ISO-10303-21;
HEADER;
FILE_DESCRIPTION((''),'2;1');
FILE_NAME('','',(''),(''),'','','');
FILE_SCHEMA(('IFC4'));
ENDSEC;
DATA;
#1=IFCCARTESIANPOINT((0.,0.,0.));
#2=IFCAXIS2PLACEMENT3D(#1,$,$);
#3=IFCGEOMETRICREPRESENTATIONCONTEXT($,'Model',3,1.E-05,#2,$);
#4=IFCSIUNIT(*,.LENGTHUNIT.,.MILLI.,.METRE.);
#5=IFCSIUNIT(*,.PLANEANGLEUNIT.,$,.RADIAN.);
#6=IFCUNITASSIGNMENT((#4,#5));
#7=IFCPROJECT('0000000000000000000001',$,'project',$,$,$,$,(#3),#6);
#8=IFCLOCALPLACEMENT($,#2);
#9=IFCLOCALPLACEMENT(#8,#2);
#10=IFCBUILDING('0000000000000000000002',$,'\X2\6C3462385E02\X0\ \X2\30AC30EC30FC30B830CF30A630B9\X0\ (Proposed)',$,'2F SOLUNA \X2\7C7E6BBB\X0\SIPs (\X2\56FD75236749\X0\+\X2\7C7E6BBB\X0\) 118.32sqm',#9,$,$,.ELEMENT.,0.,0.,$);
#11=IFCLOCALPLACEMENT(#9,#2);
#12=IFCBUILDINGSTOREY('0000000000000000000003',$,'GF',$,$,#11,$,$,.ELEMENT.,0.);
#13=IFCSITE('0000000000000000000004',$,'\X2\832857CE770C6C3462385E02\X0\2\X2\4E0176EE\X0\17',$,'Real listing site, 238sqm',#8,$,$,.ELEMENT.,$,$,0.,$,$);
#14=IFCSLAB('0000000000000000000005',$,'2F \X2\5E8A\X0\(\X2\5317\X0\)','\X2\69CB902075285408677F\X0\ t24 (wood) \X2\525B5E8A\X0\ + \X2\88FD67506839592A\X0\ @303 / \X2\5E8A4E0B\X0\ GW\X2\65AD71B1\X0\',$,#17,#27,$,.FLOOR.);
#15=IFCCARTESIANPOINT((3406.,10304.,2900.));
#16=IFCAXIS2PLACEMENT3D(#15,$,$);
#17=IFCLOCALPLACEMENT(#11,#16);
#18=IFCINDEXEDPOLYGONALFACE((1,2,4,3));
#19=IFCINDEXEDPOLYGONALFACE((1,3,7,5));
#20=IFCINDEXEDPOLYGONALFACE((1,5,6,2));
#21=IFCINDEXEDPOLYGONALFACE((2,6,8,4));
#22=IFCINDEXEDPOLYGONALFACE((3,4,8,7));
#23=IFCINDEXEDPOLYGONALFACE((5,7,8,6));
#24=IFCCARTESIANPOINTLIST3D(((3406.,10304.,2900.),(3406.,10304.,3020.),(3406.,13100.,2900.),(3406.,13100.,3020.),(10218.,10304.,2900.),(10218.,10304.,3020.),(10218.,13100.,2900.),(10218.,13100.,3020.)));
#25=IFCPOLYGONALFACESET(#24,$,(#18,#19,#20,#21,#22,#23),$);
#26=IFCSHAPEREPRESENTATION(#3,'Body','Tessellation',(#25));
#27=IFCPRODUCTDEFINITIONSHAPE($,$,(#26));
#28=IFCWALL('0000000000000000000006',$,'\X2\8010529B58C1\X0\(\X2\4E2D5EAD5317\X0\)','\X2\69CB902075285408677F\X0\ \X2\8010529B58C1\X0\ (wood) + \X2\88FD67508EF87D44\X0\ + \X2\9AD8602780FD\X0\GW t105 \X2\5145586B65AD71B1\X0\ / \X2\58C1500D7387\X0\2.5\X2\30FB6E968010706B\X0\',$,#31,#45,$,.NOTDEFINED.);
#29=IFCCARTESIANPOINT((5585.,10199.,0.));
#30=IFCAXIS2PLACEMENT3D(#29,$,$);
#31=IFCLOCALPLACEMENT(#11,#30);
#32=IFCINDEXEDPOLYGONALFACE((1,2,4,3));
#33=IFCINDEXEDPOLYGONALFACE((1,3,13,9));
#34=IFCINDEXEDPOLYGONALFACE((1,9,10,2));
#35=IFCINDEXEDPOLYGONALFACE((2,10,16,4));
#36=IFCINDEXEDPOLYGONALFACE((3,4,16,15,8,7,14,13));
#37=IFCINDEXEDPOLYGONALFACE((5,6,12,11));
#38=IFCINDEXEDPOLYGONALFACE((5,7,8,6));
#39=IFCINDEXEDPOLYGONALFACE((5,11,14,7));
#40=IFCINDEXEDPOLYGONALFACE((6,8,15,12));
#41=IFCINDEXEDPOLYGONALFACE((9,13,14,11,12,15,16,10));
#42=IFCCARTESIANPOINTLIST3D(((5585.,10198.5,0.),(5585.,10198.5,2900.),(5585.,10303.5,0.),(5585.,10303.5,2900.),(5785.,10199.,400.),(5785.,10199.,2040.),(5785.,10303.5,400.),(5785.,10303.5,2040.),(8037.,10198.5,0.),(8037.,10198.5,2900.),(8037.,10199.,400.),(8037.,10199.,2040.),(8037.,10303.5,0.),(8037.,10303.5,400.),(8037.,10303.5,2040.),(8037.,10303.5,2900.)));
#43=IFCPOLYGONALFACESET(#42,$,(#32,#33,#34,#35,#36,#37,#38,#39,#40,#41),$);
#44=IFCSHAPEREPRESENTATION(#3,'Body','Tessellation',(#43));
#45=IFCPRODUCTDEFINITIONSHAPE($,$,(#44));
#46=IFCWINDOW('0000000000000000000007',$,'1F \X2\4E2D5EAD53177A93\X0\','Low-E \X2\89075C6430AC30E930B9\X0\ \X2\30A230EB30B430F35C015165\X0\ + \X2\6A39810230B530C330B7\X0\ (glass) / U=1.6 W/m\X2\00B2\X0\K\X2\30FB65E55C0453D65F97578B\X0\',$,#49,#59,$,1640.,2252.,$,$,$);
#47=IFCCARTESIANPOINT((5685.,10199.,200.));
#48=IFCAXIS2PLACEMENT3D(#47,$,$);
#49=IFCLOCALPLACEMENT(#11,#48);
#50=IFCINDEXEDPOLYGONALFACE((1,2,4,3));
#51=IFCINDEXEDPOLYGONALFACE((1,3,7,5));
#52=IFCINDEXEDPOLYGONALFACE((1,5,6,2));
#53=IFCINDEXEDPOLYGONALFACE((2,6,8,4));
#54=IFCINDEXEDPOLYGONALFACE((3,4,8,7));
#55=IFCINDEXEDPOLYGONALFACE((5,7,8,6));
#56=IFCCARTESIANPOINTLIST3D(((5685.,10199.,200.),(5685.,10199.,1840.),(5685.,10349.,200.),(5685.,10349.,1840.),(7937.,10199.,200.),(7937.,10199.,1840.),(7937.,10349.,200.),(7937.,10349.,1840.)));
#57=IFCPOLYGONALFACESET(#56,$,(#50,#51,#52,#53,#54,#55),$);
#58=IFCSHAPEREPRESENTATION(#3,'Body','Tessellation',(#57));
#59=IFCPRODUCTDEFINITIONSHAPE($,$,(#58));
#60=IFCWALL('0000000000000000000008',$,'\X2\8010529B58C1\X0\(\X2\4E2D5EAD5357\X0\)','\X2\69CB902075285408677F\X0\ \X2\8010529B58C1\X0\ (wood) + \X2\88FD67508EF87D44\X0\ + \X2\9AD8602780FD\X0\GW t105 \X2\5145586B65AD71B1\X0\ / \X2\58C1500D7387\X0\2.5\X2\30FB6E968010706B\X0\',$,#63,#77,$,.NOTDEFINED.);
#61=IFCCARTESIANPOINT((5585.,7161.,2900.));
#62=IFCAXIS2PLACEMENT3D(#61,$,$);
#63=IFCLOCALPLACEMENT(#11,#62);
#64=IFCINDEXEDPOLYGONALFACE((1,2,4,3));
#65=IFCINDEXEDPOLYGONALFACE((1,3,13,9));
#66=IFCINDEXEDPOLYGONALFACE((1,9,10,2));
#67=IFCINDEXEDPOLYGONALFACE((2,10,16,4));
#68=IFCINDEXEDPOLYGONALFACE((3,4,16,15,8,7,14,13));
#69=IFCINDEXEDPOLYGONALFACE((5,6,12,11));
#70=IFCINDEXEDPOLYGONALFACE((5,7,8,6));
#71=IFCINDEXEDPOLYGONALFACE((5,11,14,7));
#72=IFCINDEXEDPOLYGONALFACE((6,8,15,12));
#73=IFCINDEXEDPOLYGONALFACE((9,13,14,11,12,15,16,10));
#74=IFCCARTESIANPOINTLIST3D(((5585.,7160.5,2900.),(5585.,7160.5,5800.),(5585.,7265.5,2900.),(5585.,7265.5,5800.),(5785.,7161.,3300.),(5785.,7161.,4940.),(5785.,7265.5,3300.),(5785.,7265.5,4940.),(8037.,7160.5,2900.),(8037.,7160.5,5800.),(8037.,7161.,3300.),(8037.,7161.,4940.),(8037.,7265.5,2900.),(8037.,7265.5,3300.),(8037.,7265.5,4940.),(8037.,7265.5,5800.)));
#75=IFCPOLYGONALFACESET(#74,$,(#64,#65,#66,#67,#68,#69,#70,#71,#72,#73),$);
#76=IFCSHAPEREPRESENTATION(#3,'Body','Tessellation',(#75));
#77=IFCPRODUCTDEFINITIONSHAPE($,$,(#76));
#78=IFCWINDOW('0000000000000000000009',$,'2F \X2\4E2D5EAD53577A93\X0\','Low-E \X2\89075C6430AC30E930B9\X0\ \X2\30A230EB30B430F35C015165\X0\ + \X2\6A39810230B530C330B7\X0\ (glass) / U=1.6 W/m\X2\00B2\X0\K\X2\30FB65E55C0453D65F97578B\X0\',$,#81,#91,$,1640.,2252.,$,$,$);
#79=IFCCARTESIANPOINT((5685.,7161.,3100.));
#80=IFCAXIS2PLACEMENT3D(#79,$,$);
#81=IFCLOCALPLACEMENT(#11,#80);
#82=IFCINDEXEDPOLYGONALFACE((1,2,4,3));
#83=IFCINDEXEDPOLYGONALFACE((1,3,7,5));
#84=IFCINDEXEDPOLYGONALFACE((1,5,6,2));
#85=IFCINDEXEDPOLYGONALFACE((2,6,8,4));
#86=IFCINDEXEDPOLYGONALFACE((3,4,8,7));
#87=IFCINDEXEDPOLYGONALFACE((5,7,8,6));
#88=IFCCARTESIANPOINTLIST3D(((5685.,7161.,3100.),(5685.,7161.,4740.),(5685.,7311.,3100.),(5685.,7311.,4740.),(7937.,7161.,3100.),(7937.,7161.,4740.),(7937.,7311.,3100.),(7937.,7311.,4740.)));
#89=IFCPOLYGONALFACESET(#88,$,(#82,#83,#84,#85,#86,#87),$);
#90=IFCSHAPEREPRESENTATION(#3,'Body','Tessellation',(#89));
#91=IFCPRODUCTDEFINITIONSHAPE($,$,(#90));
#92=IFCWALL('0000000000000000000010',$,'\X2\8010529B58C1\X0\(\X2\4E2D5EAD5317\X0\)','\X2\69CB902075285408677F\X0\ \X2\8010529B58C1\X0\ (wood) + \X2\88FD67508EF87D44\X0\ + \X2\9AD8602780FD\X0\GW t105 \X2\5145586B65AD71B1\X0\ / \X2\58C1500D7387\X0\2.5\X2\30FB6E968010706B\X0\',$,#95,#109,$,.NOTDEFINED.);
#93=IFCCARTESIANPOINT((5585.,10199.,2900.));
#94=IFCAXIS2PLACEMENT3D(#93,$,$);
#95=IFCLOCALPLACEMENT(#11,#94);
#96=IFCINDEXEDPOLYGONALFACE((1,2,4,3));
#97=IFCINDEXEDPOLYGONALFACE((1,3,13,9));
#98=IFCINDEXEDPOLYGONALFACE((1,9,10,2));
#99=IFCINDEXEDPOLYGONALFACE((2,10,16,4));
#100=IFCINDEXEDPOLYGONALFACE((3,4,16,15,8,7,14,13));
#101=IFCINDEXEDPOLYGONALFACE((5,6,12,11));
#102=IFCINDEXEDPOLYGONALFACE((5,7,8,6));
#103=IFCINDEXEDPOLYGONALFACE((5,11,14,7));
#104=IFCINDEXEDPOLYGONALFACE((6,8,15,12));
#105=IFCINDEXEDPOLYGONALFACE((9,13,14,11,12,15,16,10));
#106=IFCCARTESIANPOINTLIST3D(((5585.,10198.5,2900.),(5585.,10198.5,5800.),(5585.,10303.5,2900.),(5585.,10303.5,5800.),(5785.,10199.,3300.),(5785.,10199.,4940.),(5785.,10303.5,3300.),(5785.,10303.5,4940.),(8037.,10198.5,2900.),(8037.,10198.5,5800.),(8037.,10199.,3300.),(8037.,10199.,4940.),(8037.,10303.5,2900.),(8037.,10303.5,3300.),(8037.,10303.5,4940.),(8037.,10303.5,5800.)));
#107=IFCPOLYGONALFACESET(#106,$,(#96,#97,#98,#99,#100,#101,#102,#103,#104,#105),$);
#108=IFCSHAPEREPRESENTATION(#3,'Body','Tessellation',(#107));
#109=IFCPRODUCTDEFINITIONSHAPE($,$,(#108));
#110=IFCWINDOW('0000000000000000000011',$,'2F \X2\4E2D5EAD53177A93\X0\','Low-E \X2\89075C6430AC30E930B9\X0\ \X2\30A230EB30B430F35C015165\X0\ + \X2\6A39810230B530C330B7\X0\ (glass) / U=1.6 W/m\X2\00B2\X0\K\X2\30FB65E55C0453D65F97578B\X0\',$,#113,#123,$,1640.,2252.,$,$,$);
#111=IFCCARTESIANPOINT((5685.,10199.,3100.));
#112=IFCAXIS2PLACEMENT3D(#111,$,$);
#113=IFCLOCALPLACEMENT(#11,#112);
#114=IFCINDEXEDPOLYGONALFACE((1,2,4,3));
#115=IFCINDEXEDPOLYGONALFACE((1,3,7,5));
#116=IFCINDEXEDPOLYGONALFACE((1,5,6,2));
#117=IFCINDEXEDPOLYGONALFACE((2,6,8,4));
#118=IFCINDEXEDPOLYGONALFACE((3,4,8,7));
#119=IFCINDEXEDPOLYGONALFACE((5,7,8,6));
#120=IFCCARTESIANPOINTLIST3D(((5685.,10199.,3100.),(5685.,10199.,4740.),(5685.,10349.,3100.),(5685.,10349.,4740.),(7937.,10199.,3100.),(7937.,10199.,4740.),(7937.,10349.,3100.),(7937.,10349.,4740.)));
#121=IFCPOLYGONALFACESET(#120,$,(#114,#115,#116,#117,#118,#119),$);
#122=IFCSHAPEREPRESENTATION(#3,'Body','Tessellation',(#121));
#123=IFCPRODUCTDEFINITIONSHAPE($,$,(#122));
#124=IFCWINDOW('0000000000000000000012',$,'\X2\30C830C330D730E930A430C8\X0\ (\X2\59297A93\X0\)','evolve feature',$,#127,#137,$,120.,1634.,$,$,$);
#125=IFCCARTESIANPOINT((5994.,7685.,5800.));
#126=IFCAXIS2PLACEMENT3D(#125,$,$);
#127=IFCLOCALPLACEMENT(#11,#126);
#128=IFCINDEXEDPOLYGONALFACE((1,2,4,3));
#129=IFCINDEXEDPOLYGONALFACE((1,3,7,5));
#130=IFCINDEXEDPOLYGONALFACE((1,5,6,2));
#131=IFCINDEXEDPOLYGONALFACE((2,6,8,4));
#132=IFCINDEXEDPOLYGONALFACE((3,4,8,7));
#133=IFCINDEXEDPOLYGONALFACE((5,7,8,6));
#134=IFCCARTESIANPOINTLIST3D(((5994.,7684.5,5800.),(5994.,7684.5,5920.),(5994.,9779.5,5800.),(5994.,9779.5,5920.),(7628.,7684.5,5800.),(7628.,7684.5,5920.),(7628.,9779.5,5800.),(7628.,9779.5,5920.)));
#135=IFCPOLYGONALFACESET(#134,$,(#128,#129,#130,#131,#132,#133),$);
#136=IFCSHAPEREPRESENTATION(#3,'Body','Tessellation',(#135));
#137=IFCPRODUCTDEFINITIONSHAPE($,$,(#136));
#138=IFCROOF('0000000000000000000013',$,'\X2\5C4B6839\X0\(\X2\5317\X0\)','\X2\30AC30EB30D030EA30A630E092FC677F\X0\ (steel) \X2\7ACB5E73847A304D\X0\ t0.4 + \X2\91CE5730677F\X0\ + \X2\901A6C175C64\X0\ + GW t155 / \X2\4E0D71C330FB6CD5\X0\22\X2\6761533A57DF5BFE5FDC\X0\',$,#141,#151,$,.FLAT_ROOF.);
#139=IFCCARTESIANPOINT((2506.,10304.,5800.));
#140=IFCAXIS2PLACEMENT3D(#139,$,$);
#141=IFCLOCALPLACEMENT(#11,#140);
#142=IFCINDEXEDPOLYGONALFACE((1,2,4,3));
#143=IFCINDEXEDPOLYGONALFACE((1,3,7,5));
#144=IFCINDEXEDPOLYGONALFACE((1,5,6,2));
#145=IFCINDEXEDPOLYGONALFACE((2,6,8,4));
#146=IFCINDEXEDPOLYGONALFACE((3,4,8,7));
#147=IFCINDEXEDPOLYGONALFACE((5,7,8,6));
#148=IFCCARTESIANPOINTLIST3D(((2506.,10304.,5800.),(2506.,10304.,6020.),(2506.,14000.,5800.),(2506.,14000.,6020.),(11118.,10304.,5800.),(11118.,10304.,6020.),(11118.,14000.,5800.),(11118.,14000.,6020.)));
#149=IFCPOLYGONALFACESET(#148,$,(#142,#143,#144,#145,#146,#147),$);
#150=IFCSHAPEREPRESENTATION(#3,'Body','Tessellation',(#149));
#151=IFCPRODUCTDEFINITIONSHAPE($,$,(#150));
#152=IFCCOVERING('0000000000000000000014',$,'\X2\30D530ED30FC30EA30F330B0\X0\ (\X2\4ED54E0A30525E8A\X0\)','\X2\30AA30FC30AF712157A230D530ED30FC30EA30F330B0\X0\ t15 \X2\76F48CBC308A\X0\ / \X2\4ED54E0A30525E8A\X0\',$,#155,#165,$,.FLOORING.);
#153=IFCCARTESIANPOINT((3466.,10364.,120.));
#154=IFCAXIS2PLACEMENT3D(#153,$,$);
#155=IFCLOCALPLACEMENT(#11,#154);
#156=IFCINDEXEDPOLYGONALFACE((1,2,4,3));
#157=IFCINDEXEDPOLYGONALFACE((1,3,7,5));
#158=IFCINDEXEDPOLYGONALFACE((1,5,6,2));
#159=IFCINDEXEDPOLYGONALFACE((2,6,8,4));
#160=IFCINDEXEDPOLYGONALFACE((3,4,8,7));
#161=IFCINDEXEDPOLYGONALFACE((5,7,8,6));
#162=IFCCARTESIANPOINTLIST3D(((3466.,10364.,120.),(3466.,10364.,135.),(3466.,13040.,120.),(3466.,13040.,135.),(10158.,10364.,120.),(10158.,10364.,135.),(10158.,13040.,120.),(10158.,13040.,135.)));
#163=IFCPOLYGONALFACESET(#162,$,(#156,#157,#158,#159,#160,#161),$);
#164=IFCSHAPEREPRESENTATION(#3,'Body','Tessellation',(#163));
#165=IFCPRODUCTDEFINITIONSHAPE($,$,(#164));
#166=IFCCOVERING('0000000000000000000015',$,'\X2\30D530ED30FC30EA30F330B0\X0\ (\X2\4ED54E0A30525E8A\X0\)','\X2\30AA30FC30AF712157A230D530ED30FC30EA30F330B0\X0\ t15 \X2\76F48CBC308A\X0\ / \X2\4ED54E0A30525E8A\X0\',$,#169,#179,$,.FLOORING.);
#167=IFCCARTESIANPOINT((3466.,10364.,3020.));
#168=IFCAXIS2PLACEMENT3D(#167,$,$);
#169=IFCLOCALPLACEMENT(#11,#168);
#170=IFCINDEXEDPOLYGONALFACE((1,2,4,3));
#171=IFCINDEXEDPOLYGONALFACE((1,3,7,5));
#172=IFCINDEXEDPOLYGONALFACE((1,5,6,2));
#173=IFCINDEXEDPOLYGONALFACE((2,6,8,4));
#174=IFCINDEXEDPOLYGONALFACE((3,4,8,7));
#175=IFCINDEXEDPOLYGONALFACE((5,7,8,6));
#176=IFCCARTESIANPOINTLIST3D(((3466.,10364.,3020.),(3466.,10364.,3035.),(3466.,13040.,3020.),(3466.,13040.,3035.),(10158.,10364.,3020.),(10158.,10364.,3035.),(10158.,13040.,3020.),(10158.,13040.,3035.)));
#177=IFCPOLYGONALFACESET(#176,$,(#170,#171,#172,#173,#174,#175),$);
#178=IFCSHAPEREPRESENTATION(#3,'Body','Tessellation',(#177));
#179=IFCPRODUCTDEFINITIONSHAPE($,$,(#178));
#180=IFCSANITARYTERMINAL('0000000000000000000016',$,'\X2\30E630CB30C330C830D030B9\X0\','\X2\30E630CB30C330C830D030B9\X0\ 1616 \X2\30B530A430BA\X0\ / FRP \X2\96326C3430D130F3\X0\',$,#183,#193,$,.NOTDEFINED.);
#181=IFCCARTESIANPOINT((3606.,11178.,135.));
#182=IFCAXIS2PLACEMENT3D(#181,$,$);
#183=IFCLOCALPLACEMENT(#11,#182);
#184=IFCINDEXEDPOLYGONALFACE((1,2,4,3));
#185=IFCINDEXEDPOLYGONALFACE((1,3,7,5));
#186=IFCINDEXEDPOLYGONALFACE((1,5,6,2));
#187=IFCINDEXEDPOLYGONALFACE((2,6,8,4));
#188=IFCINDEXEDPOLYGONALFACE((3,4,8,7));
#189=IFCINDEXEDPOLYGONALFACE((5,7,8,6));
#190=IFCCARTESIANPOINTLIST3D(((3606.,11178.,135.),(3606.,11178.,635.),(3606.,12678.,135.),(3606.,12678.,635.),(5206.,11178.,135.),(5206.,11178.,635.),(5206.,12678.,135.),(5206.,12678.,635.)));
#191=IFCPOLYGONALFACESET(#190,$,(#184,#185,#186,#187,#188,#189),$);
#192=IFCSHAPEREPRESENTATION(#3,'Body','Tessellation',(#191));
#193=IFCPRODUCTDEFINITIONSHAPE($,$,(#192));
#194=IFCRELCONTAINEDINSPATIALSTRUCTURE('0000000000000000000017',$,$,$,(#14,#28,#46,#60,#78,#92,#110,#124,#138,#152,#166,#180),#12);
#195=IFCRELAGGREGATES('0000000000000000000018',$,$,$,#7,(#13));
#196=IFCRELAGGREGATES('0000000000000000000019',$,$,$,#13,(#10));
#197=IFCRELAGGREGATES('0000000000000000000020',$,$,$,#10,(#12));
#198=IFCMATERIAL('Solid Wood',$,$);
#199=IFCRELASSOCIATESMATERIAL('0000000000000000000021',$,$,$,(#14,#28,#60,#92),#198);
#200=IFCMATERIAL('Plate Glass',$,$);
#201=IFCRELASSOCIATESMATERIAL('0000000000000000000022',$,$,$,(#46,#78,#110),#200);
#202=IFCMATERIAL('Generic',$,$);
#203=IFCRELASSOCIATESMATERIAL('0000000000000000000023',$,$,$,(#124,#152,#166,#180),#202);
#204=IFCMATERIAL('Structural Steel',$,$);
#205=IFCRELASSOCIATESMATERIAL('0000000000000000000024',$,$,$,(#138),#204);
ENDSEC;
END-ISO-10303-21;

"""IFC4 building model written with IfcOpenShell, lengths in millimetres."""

from ifc_helpers import new_model, si_unit, frame, frame_2d, origin, place, context, project, spatial, rectangle, extrude, material, element, fill, save


model = new_model("IFC4")

# Units and contexts
model_context = context("Model", 3, precision=1e-05, world=origin())
ifc_project = project(units=[si_unit("LENGTHUNIT", "METRE", prefix="MILLI"), si_unit("PLANEANGLEUNIT", "RADIAN")], contexts=[model_context])

# Site, building, storey
site_placement = place(None, origin())
site = spatial("IfcSite", under=ifc_project, at=site_placement, Name="茨城県水戸市2丁目17", ObjectType="Real listing site, 238sqm", CompositionType="ELEMENT", RefElevation=0.0)
building_placement = place(site_placement, origin())
building = spatial("IfcBuilding", under=site, at=building_placement, Name="水戸市 ガレージハウス (Proposed)", ObjectType="2F SOLUNA 籾殻SIPs (国産杉+籾殻) 118.32sqm", CompositionType="ELEMENT", ElevationOfRefHeight=0.0, ElevationOfTerrain=0.0)
storey_placement = place(building_placement, origin())
storey = spatial("IfcBuildingStorey", under=building, at=storey_placement, Name="GF", CompositionType="ELEMENT", Elevation=0.0)

# Slab
ifc_material_1 = material(Name="Solid Wood")
slab_1_placement = place(storey_placement, frame((3406.0, 10304.0, 2900.0)))
element("IfcSlab", 1, at=slab_1_placement, inside=storey, material=ifc_material_1, Name="2F 床(北)", Description="構造用合板 t24 (wood) 剛床 + 製材根太 @303 / 床下 GW断熱", PredefinedType="FLOOR", context=model_context, shape_type="SweptSolid", body=[
    extrude(rectangle(XDim=6812.0, YDim=2796.0, at=frame_2d((3406.0, 1398.0))), frame((3406.0, 10304.0, 2900.0)), (0.0, 0.0, 1.0), 120.0),
])

# Wall, opening, window
wall_1_placement = place(storey_placement, frame((5585.0, 10199.0, 0.0)))
wall_1 = element("IfcWall", 2, at=wall_1_placement, inside=storey, material=ifc_material_1, Name="耐力壁(中庭北)", Description="構造用合板 耐力壁 (wood) + 製材軸組 + 高性能GW t105 充填断熱 / 壁倍率2.5・準耐火", PredefinedType="NOTDEFINED", context=model_context, shape_type="SweptSolid", body=[
    extrude(rectangle(XDim=2452.0, YDim=105.0, at=frame_2d((1226.0, 52.0))), frame((5585.0, 10199.0, 0.0)), (0.0, 0.0, 1.0), 2900.0),
])
opening_1_placement = place(storey_placement, frame((5685.0, 10199.0, 200.0)))
opening_1 = element("IfcOpeningElement", 3, at=opening_1_placement, cuts=wall_1, PredefinedType="NOTDEFINED", context=model_context, shape_type="SweptSolid", body=[
    extrude(rectangle(XDim=2252.0, YDim=150.0, at=frame_2d((1126.0, 75.0))), frame((5685.0, 10199.0, 200.0)), (0.0, 0.0, 1.0), 1640.0),
])
ifc_material_2 = material(Name="Plate Glass")
window_1_placement = place(storey_placement, frame((5685.0, 10199.0, 200.0)))
window_1 = element("IfcWindow", 4, at=window_1_placement, inside=storey, material=ifc_material_2, Name="1F 中庭北窓", Description="Low-E 複層ガラス アルゴン封入 + 樹脂サッシ (glass) / U=1.6 W/m²K・日射取得型", OverallHeight=1640.0, OverallWidth=2252.0, context=model_context, shape_type="SweptSolid", body=[
    extrude(rectangle(XDim=2252.0, YDim=150.0, at=frame_2d((1126.0, 75.0))), frame((5685.0, 10199.0, 200.0)), (0.0, 0.0, 1.0), 1640.0),
])
fill(opening_1, window_1)

# Walls, openings, windows
wall_2_placement = place(storey_placement, frame((5585.0, 7161.0, 2900.0)))
wall_2 = element("IfcWall", 5, at=wall_2_placement, inside=storey, material=ifc_material_1, Name="耐力壁(中庭南)", Description="構造用合板 耐力壁 (wood) + 製材軸組 + 高性能GW t105 充填断熱 / 壁倍率2.5・準耐火", PredefinedType="NOTDEFINED", context=model_context, shape_type="SweptSolid", body=[
    extrude(rectangle(XDim=2452.0, YDim=105.0, at=frame_2d((1226.0, 52.0))), frame((5585.0, 7161.0, 2900.0)), (0.0, 0.0, 1.0), 2900.0),
])
opening_2_placement = place(storey_placement, frame((5685.0, 7161.0, 3100.0)))
opening_2 = element("IfcOpeningElement", 6, at=opening_2_placement, cuts=wall_2, PredefinedType="NOTDEFINED", context=model_context, shape_type="SweptSolid", body=[
    extrude(rectangle(XDim=2252.0, YDim=150.0, at=frame_2d((1126.0, 75.0))), frame((5685.0, 7161.0, 3100.0)), (0.0, 0.0, 1.0), 1640.0),
])
window_2_placement = place(storey_placement, frame((5685.0, 7161.0, 3100.0)))
window_2 = element("IfcWindow", 7, at=window_2_placement, inside=storey, material=ifc_material_2, Name="2F 中庭南窓", Description="Low-E 複層ガラス アルゴン封入 + 樹脂サッシ (glass) / U=1.6 W/m²K・日射取得型", OverallHeight=1640.0, OverallWidth=2252.0, context=model_context, shape_type="SweptSolid", body=[
    extrude(rectangle(XDim=2252.0, YDim=150.0, at=frame_2d((1126.0, 75.0))), frame((5685.0, 7161.0, 3100.0)), (0.0, 0.0, 1.0), 1640.0),
])
fill(opening_2, window_2)
wall_3_placement = place(storey_placement, frame((5585.0, 10199.0, 2900.0)))
wall_3 = element("IfcWall", 8, at=wall_3_placement, inside=storey, material=ifc_material_1, Name="耐力壁(中庭北)", Description="構造用合板 耐力壁 (wood) + 製材軸組 + 高性能GW t105 充填断熱 / 壁倍率2.5・準耐火", PredefinedType="NOTDEFINED", context=model_context, shape_type="SweptSolid", body=[
    extrude(rectangle(XDim=2452.0, YDim=105.0, at=frame_2d((1226.0, 52.0))), frame((5585.0, 10199.0, 2900.0)), (0.0, 0.0, 1.0), 2900.0),
])
opening_3_placement = place(storey_placement, frame((5685.0, 10199.0, 3100.0)))
opening_3 = element("IfcOpeningElement", 9, at=opening_3_placement, cuts=wall_3, PredefinedType="NOTDEFINED", context=model_context, shape_type="SweptSolid", body=[
    extrude(rectangle(XDim=2252.0, YDim=150.0, at=frame_2d((1126.0, 75.0))), frame((5685.0, 10199.0, 3100.0)), (0.0, 0.0, 1.0), 1640.0),
])
window_3_placement = place(storey_placement, frame((5685.0, 10199.0, 3100.0)))
window_3 = element("IfcWindow", 10, at=window_3_placement, inside=storey, material=ifc_material_2, Name="2F 中庭北窓", Description="Low-E 複層ガラス アルゴン封入 + 樹脂サッシ (glass) / U=1.6 W/m²K・日射取得型", OverallHeight=1640.0, OverallWidth=2252.0, context=model_context, shape_type="SweptSolid", body=[
    extrude(rectangle(XDim=2252.0, YDim=150.0, at=frame_2d((1126.0, 75.0))), frame((5685.0, 10199.0, 3100.0)), (0.0, 0.0, 1.0), 1640.0),
])
fill(opening_3, window_3)

# Window
ifc_material_3 = material(Name="Generic")
window_4_placement = place(storey_placement, frame((5994.0, 7685.0, 5800.0)))
element("IfcWindow", 11, at=window_4_placement, inside=storey, material=ifc_material_3, Name="トップライト (天窓)", Description="evolve feature", OverallHeight=120.0, OverallWidth=1634.0, context=model_context, shape_type="SweptSolid", body=[
    extrude(rectangle(XDim=1634.0, YDim=2095.0, at=frame_2d((817.0, 1047.0))), frame((5994.0, 7685.0, 5800.0)), (0.0, 0.0, 1.0), 120.0),
])

# Roof
ifc_material_4 = material(Name="Structural Steel")
roof_1_placement = place(storey_placement, frame((2506.0, 10304.0, 5800.0)))
element("IfcRoof", 12, at=roof_1_placement, inside=storey, material=ifc_material_4, Name="屋根(北)", Description="ガルバリウム鋼板 (steel) 立平葺き t0.4 + 野地板 + 通気層 + GW t155 / 不燃・法22条区域対応", PredefinedType="FLAT_ROOF", context=model_context, shape_type="SweptSolid", body=[
    extrude(rectangle(XDim=8612.0, YDim=3696.0, at=frame_2d((4306.0, 1848.0))), frame((2506.0, 10304.0, 5800.0)), (0.0, 0.0, 1.0), 220.0),
])

# Coverings
covering_1_placement = place(storey_placement, frame((3466.0, 10364.0, 120.0)))
element("IfcCovering", 13, at=covering_1_placement, inside=storey, material=ifc_material_3, Name="フローリング (仕上げ床)", Description="オーク無垢フローリング t15 直貼り / 仕上げ床", PredefinedType="FLOORING", context=model_context, shape_type="SweptSolid", body=[
    extrude(rectangle(XDim=6692.0, YDim=2676.0, at=frame_2d((3346.0, 1338.0))), frame((3466.0, 10364.0, 120.0)), (0.0, 0.0, 1.0), 15.0),
])
covering_2_placement = place(storey_placement, frame((3466.0, 10364.0, 3020.0)))
element("IfcCovering", 14, at=covering_2_placement, inside=storey, material=ifc_material_3, Name="フローリング (仕上げ床)", Description="オーク無垢フローリング t15 直貼り / 仕上げ床", PredefinedType="FLOORING", context=model_context, shape_type="SweptSolid", body=[
    extrude(rectangle(XDim=6692.0, YDim=2676.0, at=frame_2d((3346.0, 1338.0))), frame((3466.0, 10364.0, 3020.0)), (0.0, 0.0, 1.0), 15.0),
])

# Sanitary terminal
sanitary_terminal_1_placement = place(storey_placement, frame((3606.0, 11178.0, 135.0)))
element("IfcSanitaryTerminal", 15, at=sanitary_terminal_1_placement, inside=storey, material=ifc_material_3, Name="ユニットバス", Description="ユニットバス 1616 サイズ / FRP 防水パン", PredefinedType="NOTDEFINED", context=model_context, shape_type="SweptSolid", body=[
    extrude(rectangle(XDim=1600.0, YDim=1500.0, at=frame_2d((800.0, 750.0))), frame((3606.0, 11178.0, 135.0)), (0.0, 0.0, 1.0), 500.0),
])

save(model, "model.ifc")
